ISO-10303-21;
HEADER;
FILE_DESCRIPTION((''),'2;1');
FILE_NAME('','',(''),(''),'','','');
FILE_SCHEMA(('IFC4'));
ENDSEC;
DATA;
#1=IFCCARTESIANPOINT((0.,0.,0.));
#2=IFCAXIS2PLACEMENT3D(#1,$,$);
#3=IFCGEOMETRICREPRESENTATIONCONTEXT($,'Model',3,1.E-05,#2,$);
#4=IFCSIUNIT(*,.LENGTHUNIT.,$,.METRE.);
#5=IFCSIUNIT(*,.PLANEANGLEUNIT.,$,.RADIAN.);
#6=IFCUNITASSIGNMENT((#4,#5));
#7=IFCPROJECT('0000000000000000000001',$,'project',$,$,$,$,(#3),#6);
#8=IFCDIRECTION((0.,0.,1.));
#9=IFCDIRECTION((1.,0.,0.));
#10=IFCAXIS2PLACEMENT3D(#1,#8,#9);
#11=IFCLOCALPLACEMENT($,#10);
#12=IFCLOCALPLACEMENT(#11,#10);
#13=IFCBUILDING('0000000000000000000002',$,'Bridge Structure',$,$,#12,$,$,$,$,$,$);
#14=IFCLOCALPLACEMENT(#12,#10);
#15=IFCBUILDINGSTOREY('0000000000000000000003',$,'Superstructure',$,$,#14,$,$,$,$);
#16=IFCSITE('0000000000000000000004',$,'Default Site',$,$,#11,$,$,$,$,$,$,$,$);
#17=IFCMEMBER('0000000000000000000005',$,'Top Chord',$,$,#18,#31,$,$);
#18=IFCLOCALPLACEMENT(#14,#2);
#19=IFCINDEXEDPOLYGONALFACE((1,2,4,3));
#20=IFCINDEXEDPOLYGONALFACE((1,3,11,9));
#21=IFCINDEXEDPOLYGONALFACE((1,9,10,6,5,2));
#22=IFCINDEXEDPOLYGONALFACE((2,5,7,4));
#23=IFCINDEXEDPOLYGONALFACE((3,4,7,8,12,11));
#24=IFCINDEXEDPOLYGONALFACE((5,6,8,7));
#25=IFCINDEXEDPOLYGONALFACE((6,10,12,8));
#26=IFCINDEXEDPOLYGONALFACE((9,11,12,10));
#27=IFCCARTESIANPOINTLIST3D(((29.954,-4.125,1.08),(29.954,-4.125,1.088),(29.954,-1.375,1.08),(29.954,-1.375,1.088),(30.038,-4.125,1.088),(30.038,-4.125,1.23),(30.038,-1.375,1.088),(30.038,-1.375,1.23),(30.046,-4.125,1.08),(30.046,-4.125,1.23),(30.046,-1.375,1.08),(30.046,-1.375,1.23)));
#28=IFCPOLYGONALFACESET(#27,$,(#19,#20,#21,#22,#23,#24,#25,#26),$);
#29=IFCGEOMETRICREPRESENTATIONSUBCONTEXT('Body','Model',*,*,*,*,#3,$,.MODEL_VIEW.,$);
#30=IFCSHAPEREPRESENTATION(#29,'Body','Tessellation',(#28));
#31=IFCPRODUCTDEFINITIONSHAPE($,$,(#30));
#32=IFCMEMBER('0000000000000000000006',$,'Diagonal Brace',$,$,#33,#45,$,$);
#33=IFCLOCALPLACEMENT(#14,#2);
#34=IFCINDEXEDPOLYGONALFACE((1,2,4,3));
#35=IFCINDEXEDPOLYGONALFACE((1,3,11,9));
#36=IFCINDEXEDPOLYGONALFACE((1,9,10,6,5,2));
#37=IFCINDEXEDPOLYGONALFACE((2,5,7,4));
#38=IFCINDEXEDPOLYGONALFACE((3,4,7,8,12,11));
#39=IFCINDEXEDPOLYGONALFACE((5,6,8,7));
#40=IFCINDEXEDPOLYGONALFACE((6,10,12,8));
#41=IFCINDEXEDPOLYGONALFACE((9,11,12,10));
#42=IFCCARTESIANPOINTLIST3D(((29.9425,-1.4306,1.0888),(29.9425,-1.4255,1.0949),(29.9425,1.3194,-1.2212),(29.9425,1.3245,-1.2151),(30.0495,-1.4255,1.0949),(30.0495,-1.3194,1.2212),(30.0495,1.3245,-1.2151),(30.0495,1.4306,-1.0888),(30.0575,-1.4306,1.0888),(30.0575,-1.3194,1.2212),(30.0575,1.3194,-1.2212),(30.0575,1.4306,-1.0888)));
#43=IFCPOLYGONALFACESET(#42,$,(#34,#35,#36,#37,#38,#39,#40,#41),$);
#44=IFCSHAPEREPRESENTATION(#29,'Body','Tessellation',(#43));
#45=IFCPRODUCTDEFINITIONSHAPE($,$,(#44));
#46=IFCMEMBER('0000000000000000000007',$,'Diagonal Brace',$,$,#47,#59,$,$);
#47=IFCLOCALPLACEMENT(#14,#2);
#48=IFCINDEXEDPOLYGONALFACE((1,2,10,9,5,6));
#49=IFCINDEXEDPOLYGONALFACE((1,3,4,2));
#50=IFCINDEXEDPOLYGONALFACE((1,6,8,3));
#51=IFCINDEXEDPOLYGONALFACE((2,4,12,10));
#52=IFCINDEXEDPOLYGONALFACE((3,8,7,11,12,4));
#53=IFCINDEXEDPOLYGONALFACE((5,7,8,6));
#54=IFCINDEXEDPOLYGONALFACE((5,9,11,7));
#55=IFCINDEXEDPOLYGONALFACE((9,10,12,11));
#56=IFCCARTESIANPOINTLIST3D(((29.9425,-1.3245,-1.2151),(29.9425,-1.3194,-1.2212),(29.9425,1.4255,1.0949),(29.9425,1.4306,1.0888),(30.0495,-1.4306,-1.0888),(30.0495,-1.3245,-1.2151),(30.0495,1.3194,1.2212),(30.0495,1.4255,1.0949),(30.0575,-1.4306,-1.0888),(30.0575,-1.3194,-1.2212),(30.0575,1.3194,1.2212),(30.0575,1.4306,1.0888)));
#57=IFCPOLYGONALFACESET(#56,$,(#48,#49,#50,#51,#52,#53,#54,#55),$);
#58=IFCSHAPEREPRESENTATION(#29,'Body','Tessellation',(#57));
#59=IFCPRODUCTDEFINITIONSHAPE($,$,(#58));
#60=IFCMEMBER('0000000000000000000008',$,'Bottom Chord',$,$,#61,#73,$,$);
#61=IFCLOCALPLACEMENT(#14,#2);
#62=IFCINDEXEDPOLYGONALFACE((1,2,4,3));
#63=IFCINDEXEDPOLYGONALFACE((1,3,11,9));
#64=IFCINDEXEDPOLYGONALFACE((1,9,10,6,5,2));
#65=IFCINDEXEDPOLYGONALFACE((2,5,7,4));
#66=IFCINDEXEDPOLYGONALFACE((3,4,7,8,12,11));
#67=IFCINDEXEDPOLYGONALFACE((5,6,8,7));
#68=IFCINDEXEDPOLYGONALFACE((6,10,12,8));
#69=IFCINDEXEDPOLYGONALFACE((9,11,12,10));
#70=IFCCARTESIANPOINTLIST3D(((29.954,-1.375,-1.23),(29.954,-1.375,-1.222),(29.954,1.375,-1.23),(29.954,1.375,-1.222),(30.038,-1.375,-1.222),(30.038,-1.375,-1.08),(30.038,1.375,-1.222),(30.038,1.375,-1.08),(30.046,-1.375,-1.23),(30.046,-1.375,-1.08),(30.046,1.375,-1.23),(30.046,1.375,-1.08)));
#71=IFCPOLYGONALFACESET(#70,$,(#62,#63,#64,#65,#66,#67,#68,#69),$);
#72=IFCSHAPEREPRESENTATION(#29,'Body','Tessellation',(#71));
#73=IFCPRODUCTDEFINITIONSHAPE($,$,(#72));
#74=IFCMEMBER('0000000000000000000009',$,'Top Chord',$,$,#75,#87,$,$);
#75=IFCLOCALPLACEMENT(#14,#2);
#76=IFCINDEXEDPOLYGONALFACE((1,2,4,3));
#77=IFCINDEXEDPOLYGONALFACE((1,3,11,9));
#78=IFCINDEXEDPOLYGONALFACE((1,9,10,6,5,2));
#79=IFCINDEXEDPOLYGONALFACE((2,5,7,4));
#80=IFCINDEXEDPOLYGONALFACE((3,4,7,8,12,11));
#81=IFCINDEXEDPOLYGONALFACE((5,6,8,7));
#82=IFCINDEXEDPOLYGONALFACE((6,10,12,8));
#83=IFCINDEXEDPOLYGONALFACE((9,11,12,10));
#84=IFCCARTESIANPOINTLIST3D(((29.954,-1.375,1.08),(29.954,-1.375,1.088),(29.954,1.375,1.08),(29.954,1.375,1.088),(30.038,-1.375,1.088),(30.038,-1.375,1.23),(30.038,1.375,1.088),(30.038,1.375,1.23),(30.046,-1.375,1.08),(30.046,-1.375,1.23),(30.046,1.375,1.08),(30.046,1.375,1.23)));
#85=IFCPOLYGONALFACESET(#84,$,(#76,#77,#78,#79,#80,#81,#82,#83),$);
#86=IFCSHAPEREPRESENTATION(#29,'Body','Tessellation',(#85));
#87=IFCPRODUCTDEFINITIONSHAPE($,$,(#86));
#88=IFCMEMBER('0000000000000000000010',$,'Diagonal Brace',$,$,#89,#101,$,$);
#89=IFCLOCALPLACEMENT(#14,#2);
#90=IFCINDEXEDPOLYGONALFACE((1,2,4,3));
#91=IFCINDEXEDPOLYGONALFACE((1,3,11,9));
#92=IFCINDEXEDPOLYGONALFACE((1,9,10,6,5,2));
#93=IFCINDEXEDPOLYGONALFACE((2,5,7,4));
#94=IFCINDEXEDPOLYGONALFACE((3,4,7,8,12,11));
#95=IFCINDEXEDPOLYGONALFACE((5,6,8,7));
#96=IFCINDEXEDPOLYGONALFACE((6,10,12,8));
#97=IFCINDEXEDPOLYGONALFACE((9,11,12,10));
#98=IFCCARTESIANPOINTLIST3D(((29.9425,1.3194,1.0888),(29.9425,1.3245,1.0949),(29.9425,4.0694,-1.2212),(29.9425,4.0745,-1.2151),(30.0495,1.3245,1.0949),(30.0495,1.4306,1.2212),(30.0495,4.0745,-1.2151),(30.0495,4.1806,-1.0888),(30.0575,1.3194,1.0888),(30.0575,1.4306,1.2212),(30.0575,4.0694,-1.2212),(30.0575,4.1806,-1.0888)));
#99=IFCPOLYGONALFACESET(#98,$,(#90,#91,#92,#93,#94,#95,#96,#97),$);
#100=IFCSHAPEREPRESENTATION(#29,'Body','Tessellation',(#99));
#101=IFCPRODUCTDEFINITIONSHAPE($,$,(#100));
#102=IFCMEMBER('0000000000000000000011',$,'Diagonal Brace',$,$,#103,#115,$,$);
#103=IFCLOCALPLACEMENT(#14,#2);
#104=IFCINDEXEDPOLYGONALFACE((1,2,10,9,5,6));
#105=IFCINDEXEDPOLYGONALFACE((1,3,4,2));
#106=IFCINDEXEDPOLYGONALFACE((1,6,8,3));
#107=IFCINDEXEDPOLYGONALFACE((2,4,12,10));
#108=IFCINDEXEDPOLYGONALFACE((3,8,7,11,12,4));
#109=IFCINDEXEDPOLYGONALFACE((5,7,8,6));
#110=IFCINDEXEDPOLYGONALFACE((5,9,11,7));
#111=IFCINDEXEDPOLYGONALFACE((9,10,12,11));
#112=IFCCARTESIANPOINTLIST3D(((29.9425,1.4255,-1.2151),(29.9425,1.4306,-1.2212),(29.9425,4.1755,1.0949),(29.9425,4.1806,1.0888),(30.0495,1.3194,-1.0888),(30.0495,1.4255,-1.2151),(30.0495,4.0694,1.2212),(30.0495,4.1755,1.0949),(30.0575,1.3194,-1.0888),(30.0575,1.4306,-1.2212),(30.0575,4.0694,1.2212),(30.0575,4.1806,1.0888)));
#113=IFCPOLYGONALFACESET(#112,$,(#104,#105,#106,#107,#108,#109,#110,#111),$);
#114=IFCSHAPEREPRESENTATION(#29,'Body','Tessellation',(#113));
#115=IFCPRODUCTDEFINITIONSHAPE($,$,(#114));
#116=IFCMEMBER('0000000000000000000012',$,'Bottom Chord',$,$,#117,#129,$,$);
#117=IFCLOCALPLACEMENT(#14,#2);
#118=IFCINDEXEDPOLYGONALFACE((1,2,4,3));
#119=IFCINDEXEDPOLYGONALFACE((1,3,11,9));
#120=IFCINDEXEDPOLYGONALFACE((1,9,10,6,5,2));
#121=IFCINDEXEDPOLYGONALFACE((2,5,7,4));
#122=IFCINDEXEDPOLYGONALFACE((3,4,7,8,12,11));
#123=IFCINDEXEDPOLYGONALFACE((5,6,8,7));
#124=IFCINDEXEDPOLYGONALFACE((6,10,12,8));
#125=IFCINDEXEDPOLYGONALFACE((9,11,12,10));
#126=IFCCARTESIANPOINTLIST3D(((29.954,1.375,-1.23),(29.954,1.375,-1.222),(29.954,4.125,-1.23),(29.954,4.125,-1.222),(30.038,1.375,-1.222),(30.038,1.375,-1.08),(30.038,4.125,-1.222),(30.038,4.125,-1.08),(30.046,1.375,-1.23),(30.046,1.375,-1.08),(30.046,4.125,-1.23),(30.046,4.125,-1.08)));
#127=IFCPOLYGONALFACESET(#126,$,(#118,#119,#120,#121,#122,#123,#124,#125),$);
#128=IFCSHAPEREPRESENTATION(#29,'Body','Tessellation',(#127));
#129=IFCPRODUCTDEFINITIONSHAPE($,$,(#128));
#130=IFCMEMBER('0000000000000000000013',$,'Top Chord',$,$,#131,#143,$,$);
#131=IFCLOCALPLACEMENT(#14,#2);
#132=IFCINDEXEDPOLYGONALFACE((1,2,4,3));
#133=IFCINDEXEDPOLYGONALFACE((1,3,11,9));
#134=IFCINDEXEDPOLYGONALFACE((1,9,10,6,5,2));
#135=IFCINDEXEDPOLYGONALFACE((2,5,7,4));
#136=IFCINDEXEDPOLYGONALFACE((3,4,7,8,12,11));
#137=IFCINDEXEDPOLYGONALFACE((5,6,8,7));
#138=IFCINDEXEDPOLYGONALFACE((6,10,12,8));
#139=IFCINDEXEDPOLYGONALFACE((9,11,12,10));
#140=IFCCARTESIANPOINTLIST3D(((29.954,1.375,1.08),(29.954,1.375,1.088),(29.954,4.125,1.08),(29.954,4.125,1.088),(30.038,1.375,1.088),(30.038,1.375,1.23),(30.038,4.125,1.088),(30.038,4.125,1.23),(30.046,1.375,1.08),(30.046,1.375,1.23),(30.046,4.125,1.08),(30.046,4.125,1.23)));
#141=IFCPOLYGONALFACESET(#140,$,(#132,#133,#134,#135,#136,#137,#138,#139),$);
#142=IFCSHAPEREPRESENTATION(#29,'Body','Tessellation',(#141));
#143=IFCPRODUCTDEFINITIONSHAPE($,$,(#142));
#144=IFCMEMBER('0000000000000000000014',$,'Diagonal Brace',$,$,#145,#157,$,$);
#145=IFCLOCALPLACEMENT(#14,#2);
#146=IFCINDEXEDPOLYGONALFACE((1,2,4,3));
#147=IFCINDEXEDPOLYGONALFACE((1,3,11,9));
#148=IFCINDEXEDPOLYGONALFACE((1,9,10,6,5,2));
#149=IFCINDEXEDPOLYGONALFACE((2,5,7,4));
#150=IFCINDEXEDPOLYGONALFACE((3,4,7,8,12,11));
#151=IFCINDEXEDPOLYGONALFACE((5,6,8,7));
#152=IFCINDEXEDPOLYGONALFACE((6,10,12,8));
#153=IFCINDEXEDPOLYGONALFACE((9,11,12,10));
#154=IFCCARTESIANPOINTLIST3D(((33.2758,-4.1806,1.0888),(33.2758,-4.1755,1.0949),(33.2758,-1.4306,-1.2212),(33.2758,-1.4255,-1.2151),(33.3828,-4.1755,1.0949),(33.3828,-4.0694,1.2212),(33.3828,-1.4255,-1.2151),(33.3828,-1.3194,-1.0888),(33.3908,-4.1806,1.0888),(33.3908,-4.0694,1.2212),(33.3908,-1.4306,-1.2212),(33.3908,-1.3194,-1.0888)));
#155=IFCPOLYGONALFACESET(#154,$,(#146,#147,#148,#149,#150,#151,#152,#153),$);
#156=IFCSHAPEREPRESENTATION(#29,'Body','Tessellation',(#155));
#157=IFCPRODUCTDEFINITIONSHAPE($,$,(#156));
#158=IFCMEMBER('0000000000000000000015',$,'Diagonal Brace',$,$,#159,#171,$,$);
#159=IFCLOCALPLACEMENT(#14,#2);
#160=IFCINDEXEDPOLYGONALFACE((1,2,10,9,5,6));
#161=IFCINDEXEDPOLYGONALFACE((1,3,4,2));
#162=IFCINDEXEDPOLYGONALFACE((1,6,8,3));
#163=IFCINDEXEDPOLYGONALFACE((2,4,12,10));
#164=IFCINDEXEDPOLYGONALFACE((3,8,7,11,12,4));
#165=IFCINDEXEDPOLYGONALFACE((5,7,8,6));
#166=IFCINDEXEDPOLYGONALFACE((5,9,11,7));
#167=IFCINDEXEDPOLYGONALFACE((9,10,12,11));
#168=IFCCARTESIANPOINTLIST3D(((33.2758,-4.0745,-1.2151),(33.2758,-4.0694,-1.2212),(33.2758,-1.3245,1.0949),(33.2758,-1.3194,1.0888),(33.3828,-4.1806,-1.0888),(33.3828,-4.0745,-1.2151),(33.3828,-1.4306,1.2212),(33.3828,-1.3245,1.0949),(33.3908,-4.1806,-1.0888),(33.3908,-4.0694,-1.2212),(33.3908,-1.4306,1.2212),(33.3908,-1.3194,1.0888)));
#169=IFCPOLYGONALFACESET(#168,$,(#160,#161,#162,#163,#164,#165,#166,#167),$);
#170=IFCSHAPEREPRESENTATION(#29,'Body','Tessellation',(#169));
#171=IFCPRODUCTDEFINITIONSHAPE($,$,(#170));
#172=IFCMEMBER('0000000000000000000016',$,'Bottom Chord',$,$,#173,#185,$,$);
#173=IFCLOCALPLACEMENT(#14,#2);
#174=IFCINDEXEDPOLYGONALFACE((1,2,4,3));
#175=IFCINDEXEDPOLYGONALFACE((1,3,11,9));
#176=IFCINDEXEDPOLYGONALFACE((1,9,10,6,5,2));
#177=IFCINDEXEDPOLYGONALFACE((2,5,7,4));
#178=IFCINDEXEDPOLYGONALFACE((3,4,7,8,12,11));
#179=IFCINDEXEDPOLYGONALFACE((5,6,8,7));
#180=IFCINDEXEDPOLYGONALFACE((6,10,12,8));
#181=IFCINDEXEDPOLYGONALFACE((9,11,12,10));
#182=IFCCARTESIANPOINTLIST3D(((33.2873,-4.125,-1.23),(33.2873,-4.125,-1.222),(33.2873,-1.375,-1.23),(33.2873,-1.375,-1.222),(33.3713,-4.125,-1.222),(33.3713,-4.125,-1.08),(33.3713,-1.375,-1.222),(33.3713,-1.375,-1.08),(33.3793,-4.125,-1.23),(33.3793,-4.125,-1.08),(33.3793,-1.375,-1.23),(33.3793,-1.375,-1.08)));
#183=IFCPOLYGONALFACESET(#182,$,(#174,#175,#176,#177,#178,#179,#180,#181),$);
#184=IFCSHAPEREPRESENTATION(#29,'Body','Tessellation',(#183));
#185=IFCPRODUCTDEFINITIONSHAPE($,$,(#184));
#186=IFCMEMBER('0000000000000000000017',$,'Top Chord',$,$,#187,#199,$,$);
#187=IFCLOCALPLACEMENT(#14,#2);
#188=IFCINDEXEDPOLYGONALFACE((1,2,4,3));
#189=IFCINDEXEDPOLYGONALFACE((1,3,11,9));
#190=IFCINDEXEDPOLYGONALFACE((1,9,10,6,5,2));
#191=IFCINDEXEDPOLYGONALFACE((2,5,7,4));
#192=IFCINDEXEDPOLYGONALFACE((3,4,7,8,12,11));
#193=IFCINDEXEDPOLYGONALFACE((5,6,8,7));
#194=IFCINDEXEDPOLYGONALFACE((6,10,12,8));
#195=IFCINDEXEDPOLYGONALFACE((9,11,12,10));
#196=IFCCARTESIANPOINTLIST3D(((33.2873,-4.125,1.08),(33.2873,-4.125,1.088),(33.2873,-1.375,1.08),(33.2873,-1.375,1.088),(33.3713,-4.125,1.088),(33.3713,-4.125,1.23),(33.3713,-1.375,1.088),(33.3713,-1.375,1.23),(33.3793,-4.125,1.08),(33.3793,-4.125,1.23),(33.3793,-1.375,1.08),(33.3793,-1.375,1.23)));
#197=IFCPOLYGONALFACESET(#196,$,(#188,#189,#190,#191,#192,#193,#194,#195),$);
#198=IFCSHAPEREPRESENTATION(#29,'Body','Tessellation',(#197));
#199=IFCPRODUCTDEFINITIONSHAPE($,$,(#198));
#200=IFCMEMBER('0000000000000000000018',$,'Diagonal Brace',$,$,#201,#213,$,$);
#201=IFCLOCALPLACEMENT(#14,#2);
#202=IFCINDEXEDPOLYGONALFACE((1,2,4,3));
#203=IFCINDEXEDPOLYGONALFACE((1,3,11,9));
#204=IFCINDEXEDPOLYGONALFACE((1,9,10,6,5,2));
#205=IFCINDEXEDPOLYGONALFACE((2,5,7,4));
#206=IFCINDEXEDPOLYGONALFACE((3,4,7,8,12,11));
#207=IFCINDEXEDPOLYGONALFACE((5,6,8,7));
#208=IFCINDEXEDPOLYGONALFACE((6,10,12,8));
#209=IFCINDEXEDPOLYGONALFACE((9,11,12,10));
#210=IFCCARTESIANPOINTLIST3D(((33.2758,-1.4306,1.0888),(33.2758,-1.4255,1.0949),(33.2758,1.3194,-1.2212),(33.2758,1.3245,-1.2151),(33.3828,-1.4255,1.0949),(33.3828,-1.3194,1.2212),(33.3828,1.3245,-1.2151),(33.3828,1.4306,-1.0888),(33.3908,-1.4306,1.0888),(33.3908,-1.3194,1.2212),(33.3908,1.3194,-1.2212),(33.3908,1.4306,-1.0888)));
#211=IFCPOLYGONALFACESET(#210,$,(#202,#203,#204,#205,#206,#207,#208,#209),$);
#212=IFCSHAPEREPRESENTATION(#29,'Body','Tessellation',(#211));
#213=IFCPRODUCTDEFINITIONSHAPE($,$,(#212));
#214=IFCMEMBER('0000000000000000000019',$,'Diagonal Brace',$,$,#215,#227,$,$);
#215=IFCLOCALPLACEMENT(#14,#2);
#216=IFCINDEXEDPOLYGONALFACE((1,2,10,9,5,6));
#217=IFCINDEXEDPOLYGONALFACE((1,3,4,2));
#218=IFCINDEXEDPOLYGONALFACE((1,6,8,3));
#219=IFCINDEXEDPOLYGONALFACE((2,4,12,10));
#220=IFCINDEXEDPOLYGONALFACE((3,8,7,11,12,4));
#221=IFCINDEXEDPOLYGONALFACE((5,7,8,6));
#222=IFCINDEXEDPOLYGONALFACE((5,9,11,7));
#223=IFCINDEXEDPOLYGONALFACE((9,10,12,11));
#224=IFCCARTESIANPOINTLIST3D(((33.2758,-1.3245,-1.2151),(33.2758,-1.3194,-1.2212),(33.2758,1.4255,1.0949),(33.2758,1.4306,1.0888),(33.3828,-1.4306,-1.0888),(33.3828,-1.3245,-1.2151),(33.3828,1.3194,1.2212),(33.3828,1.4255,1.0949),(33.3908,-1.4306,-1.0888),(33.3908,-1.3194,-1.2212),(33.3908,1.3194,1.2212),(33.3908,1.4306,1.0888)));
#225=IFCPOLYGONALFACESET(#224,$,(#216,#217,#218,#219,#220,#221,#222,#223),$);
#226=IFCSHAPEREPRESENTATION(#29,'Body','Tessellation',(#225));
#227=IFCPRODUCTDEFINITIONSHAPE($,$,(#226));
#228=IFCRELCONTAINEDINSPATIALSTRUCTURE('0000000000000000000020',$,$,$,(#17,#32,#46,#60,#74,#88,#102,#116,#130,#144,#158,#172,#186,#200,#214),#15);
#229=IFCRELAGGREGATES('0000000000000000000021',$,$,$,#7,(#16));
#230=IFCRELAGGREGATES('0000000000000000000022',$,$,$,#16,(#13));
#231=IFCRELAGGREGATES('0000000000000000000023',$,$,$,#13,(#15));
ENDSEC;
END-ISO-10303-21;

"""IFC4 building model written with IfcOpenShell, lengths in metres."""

from ifc_helpers import new_model, si_unit, frame, origin, origin_with_axes, origin_2d_with_axis, place, context, subcontext, project, spatial, l_section, extrude, element, save


model = new_model("IFC4")

# Units and contexts
model_context = context("Model", 3, precision=1e-05, world=origin())
body_context = subcontext(model_context, "Body", "Model", "MODEL_VIEW")
ifc_project = project(units=[si_unit("LENGTHUNIT", "METRE"), si_unit("PLANEANGLEUNIT", "RADIAN")], contexts=[model_context])

# Site, building, storey
site_placement = place(None, origin_with_axes())
site = spatial("IfcSite", under=ifc_project, at=site_placement, Name="Default Site")
building_placement = place(site_placement, origin_with_axes())
building = spatial("IfcBuilding", under=site, at=building_placement, Name="Bridge Structure")
storey_placement = place(building_placement, origin_with_axes())
storey = spatial("IfcBuildingStorey", under=building, at=storey_placement, Name="Superstructure")

# Members
member_placement = place(storey_placement, frame((30.0, -4.125, 1.155), z_axis=(0.0, 1.0, 0.0), x_axis=(-1.0, 0.0, 0.0)))
element("IfcMember", 1, at=member_placement, inside=storey, Name="Top Chord", context=body_context, shape_type="SweptSolid", body=[
    extrude(l_section(Depth=0.15, Width=0.092, Thickness=0.008, at=origin_2d_with_axis()), origin_with_axes(), (0.0, 0.0, 1.0), 2.75),
])
for number, where, z_axis, x_axis, name in (
    (2, (30.0, -1.375, 1.155), (0.0, 0.765705, -0.643192), (-1.0, 0.0, 0.0), "Diagonal Brace"),
    (3, (30.0, -1.375, -1.155), (0.0, 0.765705, 0.643192), (-1.0, 0.0, 0.0), "Diagonal Brace"),
):
    element("IfcMember", number, at=place(storey_placement, frame(where, z_axis=z_axis, x_axis=x_axis)), inside=storey, Name=name, context=body_context, shape_type="SweptSolid", body=[
        extrude(l_section(Depth=0.173, Width=0.115, Thickness=0.008, at=origin_2d_with_axis()), origin_with_axes(), (0.0, 0.0, 1.0), 3.5915),
    ])
for number, where, z_axis, x_axis, name in (
    (4, (30.0, -1.375, -1.155), (0.0, 1.0, 0.0), (-1.0, 0.0, 0.0), "Bottom Chord"),
    (5, (30.0, -1.375, 1.155), (0.0, 1.0, 0.0), (-1.0, 0.0, 0.0), "Top Chord"),
):
    element("IfcMember", number, at=place(storey_placement, frame(where, z_axis=z_axis, x_axis=x_axis)), inside=storey, Name=name, context=body_context, shape_type="SweptSolid", body=[
        extrude(l_section(Depth=0.15, Width=0.092, Thickness=0.008, at=origin_2d_with_axis()), origin_with_axes(), (0.0, 0.0, 1.0), 2.75),
    ])
for number, where, z_axis, x_axis, name in (
    (6, (30.0, 1.375, 1.155), (0.0, 0.765705, -0.643192), (-1.0, 0.0, 0.0), "Diagonal Brace"),
    (7, (30.0, 1.375, -1.155), (0.0, 0.765705, 0.643192), (-1.0, 0.0, 0.0), "Diagonal Brace"),
):
    element("IfcMember", number, at=place(storey_placement, frame(where, z_axis=z_axis, x_axis=x_axis)), inside=storey, Name=name, context=body_context, shape_type="SweptSolid", body=[
        extrude(l_section(Depth=0.173, Width=0.115, Thickness=0.008, at=origin_2d_with_axis()), origin_with_axes(), (0.0, 0.0, 1.0), 3.5915),
    ])
for number, where, z_axis, x_axis, name in (
    (8, (30.0, 1.375, -1.155), (0.0, 1.0, 0.0), (-1.0, 0.0, 0.0), "Bottom Chord"),
    (9, (30.0, 1.375, 1.155), (0.0, 1.0, 0.0), (-1.0, 0.0, 0.0), "Top Chord"),
):
    element("IfcMember", number, at=place(storey_placement, frame(where, z_axis=z_axis, x_axis=x_axis)), inside=storey, Name=name, context=body_context, shape_type="SweptSolid", body=[
        extrude(l_section(Depth=0.15, Width=0.092, Thickness=0.008, at=origin_2d_with_axis()), origin_with_axes(), (0.0, 0.0, 1.0), 2.75),
    ])
for number, where, z_axis, x_axis, name in (
    (10, (33.3333, -4.125, 1.155), (0.0, 0.765705, -0.643192), (-1.0, 0.0, 0.0), "Diagonal Brace"),
    (11, (33.3333, -4.125, -1.155), (0.0, 0.765705, 0.643192), (-1.0, 0.0, 0.0), "Diagonal Brace"),
):
    element("IfcMember", number, at=place(storey_placement, frame(where, z_axis=z_axis, x_axis=x_axis)), inside=storey, Name=name, context=body_context, shape_type="SweptSolid", body=[
        extrude(l_section(Depth=0.173, Width=0.115, Thickness=0.008, at=origin_2d_with_axis()), origin_with_axes(), (0.0, 0.0, 1.0), 3.5915),
    ])
for number, where, z_axis, x_axis, name in (
    (12, (33.3333, -4.125, -1.155), (0.0, 1.0, 0.0), (-1.0, 0.0, 0.0), "Bottom Chord"),
    (13, (33.3333, -4.125, 1.155), (0.0, 1.0, 0.0), (-1.0, 0.0, 0.0), "Top Chord"),
):
    element("IfcMember", number, at=place(storey_placement, frame(where, z_axis=z_axis, x_axis=x_axis)), inside=storey, Name=name, context=body_context, shape_type="SweptSolid", body=[
        extrude(l_section(Depth=0.15, Width=0.092, Thickness=0.008, at=origin_2d_with_axis()), origin_with_axes(), (0.0, 0.0, 1.0), 2.75),
    ])
for number, where, z_axis, x_axis, name in (
    (14, (33.3333, -1.375, 1.155), (0.0, 0.765705, -0.643192), (-1.0, 0.0, 0.0), "Diagonal Brace"),
    (15, (33.3333, -1.375, -1.155), (0.0, 0.765705, 0.643192), (-1.0, 0.0, 0.0), "Diagonal Brace"),
):
    element("IfcMember", number, at=place(storey_placement, frame(where, z_axis=z_axis, x_axis=x_axis)), inside=storey, Name=name, context=body_context, shape_type="SweptSolid", body=[
        extrude(l_section(Depth=0.173, Width=0.115, Thickness=0.008, at=origin_2d_with_axis()), origin_with_axes(), (0.0, 0.0, 1.0), 3.5915),
    ])

save(model, "model.ifc")
